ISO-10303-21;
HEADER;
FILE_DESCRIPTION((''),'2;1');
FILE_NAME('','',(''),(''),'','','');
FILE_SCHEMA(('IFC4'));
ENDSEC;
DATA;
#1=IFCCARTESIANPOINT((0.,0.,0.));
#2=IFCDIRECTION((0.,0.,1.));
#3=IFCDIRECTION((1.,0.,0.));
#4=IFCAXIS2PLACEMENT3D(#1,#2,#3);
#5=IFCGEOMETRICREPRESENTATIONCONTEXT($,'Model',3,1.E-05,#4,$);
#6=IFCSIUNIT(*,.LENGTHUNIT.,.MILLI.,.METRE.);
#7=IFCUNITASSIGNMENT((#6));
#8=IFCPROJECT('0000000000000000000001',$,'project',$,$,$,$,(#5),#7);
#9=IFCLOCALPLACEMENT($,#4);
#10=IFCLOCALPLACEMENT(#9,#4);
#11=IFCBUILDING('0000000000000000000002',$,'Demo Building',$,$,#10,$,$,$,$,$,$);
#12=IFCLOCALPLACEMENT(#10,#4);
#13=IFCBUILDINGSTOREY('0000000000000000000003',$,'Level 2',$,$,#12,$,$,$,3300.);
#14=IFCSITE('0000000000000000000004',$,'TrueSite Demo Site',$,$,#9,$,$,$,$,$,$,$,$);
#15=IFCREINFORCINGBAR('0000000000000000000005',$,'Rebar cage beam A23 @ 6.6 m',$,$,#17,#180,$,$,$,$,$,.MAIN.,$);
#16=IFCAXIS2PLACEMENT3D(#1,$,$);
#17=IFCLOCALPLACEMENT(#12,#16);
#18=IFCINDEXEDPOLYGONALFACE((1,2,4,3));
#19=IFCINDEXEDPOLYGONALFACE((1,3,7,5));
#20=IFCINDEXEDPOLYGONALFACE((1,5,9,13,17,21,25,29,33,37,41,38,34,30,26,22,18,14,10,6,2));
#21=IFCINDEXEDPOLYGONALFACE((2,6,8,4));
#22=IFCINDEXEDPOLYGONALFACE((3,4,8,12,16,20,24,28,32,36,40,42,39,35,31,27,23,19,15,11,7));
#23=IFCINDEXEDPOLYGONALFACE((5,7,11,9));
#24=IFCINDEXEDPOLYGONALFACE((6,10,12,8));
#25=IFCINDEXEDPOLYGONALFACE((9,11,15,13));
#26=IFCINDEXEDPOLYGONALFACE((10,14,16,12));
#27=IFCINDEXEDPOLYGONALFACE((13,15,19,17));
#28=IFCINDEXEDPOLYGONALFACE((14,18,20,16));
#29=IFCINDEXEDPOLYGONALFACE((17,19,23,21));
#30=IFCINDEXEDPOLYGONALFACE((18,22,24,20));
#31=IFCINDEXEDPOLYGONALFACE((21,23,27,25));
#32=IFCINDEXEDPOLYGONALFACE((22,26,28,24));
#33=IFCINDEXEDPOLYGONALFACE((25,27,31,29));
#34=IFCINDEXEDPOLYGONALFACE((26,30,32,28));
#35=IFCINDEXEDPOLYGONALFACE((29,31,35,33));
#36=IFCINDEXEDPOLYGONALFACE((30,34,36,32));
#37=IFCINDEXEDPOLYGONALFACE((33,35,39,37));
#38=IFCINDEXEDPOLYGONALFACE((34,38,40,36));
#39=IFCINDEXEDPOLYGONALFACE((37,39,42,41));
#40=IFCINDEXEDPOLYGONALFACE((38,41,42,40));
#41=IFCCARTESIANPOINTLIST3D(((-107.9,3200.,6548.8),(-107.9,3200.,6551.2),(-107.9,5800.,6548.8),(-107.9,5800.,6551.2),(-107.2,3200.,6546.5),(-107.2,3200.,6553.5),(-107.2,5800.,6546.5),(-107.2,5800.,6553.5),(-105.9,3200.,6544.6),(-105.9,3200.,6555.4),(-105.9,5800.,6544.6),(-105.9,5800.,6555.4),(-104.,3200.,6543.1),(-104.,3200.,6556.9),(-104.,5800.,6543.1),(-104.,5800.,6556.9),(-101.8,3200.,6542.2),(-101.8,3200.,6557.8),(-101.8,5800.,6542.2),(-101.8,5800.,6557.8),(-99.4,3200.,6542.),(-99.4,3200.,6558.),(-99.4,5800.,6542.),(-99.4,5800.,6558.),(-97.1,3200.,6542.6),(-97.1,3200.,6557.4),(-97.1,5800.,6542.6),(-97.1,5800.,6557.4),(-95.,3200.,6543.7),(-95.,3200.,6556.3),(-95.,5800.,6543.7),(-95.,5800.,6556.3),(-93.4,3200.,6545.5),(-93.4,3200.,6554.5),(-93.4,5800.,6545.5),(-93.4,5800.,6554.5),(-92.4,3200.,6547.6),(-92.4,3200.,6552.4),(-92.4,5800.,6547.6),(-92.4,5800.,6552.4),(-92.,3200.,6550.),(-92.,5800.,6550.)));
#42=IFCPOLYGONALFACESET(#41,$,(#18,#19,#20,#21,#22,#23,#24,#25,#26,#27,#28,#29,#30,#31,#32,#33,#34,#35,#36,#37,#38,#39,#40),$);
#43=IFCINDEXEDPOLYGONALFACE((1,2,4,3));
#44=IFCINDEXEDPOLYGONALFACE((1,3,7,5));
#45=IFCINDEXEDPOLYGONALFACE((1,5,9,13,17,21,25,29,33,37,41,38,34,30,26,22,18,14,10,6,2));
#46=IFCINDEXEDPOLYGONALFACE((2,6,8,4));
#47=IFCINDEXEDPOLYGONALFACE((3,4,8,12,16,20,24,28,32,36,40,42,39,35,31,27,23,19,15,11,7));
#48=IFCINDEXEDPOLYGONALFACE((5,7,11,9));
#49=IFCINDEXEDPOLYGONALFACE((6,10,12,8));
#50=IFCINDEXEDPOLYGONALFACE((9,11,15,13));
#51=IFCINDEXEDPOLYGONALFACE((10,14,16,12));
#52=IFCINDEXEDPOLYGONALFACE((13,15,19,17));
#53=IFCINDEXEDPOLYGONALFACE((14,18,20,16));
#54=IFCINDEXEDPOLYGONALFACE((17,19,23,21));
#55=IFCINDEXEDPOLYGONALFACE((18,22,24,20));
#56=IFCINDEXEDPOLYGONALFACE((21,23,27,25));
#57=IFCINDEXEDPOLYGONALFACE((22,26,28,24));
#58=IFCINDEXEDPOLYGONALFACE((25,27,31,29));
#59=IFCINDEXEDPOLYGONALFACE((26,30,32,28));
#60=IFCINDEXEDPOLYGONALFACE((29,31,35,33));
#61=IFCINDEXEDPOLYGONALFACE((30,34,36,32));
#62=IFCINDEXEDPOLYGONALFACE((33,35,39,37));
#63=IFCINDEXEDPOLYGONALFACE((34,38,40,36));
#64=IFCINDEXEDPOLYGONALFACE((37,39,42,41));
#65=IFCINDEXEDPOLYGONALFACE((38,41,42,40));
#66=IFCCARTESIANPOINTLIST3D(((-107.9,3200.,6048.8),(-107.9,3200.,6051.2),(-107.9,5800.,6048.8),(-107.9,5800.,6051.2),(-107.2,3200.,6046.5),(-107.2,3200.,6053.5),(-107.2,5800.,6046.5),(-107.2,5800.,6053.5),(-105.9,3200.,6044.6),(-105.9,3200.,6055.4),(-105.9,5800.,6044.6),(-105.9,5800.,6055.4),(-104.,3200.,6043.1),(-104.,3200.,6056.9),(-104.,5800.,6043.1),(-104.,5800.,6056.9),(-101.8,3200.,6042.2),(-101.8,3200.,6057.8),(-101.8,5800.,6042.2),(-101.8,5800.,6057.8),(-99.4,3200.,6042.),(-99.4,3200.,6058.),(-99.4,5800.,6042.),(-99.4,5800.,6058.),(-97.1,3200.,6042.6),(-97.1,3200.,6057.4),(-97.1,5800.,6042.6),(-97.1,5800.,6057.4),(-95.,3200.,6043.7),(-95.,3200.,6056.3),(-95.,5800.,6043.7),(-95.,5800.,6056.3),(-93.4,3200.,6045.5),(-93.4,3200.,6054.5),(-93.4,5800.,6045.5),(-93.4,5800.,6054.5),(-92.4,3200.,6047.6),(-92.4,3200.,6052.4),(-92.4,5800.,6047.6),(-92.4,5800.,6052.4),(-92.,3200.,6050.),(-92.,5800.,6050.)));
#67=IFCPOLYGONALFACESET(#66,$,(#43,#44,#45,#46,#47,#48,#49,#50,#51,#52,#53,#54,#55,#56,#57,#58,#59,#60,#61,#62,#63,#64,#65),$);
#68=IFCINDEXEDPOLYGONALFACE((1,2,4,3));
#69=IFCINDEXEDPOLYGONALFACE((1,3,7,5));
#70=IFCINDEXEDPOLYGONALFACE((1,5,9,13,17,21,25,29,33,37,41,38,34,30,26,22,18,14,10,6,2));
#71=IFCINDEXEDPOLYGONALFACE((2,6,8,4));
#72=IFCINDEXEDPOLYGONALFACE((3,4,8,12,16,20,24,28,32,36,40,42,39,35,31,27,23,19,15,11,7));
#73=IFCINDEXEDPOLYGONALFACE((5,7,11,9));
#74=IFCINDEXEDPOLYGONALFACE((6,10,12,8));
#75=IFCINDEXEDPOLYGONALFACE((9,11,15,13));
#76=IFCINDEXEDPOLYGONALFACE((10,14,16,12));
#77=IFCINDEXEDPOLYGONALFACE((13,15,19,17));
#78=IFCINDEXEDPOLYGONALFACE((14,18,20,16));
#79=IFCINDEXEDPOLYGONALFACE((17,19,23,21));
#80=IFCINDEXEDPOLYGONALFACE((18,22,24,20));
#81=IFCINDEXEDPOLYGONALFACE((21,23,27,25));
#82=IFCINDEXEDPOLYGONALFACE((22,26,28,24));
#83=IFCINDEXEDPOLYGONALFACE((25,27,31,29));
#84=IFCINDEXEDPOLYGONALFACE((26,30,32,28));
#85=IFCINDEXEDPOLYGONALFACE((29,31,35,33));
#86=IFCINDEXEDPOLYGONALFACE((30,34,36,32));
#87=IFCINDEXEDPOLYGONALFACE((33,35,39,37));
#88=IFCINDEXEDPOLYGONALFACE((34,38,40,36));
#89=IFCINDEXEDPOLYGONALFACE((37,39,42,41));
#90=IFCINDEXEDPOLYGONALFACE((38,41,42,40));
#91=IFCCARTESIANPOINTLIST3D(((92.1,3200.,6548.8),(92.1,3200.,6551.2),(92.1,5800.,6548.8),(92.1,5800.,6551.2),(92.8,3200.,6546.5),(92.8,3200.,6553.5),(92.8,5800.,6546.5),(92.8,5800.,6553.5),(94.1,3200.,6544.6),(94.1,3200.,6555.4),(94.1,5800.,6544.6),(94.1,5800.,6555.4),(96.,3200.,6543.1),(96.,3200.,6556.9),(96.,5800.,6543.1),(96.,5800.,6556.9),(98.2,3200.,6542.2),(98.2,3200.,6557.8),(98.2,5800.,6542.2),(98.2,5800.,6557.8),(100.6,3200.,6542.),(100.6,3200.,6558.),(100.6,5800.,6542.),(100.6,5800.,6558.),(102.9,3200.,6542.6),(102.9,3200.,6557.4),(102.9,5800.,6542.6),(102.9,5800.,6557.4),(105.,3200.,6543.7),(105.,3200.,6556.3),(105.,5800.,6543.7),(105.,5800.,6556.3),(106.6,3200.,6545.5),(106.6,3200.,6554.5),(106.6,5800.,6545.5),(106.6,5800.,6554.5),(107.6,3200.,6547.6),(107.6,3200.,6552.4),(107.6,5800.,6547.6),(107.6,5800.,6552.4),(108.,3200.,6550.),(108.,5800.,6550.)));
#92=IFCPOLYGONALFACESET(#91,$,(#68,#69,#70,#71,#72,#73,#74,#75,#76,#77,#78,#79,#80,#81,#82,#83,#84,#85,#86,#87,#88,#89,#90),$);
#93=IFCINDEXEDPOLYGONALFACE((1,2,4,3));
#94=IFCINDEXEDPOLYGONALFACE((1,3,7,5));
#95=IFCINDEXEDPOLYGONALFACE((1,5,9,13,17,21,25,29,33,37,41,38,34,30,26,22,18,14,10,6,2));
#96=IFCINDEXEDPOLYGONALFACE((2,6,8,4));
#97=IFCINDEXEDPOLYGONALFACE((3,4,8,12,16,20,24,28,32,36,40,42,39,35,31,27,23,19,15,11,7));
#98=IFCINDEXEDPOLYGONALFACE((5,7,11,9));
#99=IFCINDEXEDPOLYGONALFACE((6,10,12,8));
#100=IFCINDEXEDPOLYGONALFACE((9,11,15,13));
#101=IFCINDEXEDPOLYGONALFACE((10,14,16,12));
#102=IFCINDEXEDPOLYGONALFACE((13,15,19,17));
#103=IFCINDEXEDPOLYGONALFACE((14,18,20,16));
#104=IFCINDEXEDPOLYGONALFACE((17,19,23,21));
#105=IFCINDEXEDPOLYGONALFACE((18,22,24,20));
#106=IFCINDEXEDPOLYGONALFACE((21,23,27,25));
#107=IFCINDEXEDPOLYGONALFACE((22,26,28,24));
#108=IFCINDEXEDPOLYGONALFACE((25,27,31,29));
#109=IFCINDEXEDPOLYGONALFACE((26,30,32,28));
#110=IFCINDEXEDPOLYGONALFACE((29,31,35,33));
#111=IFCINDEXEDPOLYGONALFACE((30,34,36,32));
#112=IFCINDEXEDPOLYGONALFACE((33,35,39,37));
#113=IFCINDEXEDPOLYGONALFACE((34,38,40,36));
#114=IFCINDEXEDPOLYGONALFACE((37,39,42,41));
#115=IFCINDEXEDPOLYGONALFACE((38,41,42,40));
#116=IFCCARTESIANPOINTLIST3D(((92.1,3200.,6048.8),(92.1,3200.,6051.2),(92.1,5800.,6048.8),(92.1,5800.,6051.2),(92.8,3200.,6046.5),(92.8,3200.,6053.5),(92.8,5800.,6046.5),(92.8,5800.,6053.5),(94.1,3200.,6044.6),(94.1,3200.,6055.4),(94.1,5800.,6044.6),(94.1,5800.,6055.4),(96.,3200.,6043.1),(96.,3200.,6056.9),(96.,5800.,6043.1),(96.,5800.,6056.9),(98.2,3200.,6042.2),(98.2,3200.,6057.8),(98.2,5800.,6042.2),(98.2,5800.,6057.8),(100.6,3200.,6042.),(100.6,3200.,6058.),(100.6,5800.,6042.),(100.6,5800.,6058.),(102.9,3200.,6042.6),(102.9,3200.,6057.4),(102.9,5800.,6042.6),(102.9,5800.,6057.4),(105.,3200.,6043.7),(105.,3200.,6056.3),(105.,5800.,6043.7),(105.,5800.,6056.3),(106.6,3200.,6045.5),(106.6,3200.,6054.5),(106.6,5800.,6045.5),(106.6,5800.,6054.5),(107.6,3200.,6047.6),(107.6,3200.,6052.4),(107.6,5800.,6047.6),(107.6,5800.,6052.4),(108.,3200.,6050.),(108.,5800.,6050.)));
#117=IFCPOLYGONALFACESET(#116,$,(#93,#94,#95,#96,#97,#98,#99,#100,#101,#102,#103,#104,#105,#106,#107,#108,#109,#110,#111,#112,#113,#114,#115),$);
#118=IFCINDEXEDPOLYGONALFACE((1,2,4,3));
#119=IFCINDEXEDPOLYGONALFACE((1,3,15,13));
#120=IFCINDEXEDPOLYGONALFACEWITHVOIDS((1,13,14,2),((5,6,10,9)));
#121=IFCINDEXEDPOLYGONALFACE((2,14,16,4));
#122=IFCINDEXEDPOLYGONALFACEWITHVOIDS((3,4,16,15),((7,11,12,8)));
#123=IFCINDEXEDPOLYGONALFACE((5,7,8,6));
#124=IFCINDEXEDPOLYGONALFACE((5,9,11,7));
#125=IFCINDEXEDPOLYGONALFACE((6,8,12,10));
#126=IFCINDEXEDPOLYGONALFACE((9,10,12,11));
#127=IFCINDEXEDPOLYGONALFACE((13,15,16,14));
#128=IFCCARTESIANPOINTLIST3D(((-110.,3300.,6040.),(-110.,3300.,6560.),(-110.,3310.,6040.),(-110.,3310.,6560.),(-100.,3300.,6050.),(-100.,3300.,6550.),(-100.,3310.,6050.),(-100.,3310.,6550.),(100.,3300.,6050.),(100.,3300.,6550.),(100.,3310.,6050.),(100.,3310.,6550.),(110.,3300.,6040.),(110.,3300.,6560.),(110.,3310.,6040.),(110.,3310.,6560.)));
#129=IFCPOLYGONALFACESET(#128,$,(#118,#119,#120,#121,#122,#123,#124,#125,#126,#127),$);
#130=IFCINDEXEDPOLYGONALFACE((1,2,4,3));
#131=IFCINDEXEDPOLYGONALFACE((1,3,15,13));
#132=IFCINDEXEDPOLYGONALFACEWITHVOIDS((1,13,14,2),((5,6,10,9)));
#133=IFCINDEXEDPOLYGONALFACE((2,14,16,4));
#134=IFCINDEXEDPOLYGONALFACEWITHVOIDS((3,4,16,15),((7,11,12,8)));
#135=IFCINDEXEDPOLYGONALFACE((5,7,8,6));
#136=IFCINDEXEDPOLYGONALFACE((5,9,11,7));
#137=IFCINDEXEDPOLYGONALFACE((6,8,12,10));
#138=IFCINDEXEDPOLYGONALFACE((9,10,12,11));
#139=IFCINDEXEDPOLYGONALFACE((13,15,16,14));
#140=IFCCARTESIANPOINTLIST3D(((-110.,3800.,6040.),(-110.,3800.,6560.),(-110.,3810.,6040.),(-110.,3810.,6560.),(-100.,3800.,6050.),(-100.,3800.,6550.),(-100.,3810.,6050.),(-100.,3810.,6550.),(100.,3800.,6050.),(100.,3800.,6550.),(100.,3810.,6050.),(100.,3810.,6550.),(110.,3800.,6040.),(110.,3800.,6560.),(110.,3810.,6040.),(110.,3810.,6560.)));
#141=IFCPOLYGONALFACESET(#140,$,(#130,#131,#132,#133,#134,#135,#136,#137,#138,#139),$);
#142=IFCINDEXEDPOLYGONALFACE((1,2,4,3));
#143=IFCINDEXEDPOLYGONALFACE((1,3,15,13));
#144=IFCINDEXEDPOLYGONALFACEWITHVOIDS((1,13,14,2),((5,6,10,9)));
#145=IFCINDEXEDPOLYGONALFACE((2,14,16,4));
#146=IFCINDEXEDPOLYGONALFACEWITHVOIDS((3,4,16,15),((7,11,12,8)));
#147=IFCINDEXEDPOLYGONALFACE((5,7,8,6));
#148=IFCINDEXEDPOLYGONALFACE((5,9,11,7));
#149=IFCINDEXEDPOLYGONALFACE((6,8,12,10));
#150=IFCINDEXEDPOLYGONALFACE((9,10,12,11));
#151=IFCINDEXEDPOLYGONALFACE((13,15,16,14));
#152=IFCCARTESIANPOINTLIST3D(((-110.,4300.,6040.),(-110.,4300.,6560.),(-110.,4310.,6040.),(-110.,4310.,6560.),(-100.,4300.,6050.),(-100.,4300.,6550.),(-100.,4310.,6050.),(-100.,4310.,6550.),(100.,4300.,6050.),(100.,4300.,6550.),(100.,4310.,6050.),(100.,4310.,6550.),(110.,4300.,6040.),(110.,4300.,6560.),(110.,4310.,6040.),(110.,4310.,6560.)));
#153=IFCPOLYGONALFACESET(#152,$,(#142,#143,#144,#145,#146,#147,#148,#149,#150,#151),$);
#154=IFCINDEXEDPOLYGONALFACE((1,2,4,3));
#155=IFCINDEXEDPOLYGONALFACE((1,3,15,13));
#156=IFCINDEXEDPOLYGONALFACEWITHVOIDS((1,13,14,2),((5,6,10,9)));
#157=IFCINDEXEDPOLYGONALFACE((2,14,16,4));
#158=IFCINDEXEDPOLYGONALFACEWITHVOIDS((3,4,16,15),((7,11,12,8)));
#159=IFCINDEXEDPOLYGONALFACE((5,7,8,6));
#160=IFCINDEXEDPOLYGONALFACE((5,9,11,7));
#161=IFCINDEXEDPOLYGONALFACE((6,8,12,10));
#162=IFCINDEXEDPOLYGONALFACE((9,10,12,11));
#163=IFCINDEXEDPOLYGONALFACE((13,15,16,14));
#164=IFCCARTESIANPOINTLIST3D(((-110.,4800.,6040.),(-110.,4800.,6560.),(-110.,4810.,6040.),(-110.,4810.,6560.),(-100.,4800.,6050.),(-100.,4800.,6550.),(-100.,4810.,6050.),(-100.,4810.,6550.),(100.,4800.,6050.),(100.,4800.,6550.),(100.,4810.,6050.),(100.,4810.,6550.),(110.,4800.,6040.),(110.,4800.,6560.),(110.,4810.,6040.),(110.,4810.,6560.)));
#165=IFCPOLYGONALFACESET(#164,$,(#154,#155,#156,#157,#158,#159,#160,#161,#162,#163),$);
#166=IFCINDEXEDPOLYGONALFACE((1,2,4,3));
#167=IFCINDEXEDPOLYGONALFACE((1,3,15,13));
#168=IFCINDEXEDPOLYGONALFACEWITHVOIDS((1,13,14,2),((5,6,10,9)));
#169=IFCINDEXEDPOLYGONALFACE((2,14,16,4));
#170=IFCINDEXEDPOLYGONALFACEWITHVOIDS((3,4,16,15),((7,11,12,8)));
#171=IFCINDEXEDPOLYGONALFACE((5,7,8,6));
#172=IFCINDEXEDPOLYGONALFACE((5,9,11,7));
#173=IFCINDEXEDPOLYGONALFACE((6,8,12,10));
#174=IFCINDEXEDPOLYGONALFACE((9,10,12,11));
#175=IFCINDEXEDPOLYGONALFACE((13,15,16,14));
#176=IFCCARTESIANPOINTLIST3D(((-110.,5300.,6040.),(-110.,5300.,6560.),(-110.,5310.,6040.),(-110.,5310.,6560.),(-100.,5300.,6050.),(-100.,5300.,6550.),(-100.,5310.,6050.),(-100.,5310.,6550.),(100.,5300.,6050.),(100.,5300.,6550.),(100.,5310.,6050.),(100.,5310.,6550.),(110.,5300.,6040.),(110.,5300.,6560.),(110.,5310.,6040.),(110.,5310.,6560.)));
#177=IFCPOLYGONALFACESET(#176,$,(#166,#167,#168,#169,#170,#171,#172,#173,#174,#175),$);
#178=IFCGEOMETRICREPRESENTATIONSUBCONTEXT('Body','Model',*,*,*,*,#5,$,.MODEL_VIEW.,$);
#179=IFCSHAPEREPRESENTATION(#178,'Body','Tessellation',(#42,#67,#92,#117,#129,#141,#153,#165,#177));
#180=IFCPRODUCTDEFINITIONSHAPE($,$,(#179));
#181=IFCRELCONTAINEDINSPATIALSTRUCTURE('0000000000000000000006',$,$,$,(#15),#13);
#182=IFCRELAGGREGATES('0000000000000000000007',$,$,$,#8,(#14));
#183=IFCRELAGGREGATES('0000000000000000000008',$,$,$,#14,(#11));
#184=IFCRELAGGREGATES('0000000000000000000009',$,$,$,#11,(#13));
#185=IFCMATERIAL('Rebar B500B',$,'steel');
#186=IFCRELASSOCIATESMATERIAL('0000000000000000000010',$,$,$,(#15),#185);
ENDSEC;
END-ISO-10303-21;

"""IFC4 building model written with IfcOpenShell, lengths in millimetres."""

from ifc_helpers import new_model, si_unit, frame, origin_with_axes, place, context, subcontext, project, spatial, hollow_rectangle, circle, extrude, material, element, save


model = new_model("IFC4")

# Units and contexts
model_context = context("Model", 3, precision=1e-05, world=origin_with_axes())
body_context = subcontext(model_context, "Body", "Model", "MODEL_VIEW")
ifc_project = project(units=[si_unit("LENGTHUNIT", "METRE", prefix="MILLI")], contexts=[model_context])

# Site, building, storey
site_placement = place(None, origin_with_axes())
site = spatial("IfcSite", under=ifc_project, at=site_placement, Name="TrueSite Demo Site")
building_placement = place(site_placement, origin_with_axes())
building = spatial("IfcBuilding", under=site, at=building_placement, Name="Demo Building")
storey_placement = place(building_placement, origin_with_axes())
storey = spatial("IfcBuildingStorey", under=building, at=storey_placement, Name="Level 2", Elevation=3300.0)

# Reinforcing bar
ifc_material_1 = material(Name="Rebar B500B", Category="steel")
for number, where, z_axis, x_axis, name in (
    (1, (0.0, 3200.0, 6300.0), (0.0, 1.0, 0.0), (1.0, 0.0, 0.0), "Rebar cage beam A23 @ 6.6 m"),
):
    element("IfcReinforcingBar", number, at=place(storey_placement, frame(where, z_axis=z_axis, x_axis=x_axis)), inside=storey, material=ifc_material_1, Name=name, PredefinedType="MAIN", context=body_context, shape_type="SweptSolid", body=[
        extrude(circle(Radius=8.0), frame((-100.0, -250.0, 0.0)), (0.0, 0.0, 1.0), 2600.0),
        extrude(circle(Radius=8.0), frame((-100.0, 250.0, 0.0)), (0.0, 0.0, 1.0), 2600.0),
        extrude(circle(Radius=8.0), frame((100.0, -250.0, 0.0)), (0.0, 0.0, 1.0), 2600.0),
        extrude(circle(Radius=8.0), frame((100.0, 250.0, 0.0)), (0.0, 0.0, 1.0), 2600.0),
        extrude(hollow_rectangle(XDim=220.0, YDim=520.0, WallThickness=10.0), frame((0.0, 0.0, 100.0)), (0.0, 0.0, 1.0), 10.0),
        extrude(hollow_rectangle(XDim=220.0, YDim=520.0, WallThickness=10.0), frame((0.0, 0.0, 600.0)), (0.0, 0.0, 1.0), 10.0),
        extrude(hollow_rectangle(XDim=220.0, YDim=520.0, WallThickness=10.0), frame((0.0, 0.0, 1100.0)), (0.0, 0.0, 1.0), 10.0),
        extrude(hollow_rectangle(XDim=220.0, YDim=520.0, WallThickness=10.0), frame((0.0, 0.0, 1600.0)), (0.0, 0.0, 1.0), 10.0),
        extrude(hollow_rectangle(XDim=220.0, YDim=520.0, WallThickness=10.0), frame((0.0, 0.0, 2100.0)), (0.0, 0.0, 1.0), 10.0),
    ])

save(model, "model.ifc")
